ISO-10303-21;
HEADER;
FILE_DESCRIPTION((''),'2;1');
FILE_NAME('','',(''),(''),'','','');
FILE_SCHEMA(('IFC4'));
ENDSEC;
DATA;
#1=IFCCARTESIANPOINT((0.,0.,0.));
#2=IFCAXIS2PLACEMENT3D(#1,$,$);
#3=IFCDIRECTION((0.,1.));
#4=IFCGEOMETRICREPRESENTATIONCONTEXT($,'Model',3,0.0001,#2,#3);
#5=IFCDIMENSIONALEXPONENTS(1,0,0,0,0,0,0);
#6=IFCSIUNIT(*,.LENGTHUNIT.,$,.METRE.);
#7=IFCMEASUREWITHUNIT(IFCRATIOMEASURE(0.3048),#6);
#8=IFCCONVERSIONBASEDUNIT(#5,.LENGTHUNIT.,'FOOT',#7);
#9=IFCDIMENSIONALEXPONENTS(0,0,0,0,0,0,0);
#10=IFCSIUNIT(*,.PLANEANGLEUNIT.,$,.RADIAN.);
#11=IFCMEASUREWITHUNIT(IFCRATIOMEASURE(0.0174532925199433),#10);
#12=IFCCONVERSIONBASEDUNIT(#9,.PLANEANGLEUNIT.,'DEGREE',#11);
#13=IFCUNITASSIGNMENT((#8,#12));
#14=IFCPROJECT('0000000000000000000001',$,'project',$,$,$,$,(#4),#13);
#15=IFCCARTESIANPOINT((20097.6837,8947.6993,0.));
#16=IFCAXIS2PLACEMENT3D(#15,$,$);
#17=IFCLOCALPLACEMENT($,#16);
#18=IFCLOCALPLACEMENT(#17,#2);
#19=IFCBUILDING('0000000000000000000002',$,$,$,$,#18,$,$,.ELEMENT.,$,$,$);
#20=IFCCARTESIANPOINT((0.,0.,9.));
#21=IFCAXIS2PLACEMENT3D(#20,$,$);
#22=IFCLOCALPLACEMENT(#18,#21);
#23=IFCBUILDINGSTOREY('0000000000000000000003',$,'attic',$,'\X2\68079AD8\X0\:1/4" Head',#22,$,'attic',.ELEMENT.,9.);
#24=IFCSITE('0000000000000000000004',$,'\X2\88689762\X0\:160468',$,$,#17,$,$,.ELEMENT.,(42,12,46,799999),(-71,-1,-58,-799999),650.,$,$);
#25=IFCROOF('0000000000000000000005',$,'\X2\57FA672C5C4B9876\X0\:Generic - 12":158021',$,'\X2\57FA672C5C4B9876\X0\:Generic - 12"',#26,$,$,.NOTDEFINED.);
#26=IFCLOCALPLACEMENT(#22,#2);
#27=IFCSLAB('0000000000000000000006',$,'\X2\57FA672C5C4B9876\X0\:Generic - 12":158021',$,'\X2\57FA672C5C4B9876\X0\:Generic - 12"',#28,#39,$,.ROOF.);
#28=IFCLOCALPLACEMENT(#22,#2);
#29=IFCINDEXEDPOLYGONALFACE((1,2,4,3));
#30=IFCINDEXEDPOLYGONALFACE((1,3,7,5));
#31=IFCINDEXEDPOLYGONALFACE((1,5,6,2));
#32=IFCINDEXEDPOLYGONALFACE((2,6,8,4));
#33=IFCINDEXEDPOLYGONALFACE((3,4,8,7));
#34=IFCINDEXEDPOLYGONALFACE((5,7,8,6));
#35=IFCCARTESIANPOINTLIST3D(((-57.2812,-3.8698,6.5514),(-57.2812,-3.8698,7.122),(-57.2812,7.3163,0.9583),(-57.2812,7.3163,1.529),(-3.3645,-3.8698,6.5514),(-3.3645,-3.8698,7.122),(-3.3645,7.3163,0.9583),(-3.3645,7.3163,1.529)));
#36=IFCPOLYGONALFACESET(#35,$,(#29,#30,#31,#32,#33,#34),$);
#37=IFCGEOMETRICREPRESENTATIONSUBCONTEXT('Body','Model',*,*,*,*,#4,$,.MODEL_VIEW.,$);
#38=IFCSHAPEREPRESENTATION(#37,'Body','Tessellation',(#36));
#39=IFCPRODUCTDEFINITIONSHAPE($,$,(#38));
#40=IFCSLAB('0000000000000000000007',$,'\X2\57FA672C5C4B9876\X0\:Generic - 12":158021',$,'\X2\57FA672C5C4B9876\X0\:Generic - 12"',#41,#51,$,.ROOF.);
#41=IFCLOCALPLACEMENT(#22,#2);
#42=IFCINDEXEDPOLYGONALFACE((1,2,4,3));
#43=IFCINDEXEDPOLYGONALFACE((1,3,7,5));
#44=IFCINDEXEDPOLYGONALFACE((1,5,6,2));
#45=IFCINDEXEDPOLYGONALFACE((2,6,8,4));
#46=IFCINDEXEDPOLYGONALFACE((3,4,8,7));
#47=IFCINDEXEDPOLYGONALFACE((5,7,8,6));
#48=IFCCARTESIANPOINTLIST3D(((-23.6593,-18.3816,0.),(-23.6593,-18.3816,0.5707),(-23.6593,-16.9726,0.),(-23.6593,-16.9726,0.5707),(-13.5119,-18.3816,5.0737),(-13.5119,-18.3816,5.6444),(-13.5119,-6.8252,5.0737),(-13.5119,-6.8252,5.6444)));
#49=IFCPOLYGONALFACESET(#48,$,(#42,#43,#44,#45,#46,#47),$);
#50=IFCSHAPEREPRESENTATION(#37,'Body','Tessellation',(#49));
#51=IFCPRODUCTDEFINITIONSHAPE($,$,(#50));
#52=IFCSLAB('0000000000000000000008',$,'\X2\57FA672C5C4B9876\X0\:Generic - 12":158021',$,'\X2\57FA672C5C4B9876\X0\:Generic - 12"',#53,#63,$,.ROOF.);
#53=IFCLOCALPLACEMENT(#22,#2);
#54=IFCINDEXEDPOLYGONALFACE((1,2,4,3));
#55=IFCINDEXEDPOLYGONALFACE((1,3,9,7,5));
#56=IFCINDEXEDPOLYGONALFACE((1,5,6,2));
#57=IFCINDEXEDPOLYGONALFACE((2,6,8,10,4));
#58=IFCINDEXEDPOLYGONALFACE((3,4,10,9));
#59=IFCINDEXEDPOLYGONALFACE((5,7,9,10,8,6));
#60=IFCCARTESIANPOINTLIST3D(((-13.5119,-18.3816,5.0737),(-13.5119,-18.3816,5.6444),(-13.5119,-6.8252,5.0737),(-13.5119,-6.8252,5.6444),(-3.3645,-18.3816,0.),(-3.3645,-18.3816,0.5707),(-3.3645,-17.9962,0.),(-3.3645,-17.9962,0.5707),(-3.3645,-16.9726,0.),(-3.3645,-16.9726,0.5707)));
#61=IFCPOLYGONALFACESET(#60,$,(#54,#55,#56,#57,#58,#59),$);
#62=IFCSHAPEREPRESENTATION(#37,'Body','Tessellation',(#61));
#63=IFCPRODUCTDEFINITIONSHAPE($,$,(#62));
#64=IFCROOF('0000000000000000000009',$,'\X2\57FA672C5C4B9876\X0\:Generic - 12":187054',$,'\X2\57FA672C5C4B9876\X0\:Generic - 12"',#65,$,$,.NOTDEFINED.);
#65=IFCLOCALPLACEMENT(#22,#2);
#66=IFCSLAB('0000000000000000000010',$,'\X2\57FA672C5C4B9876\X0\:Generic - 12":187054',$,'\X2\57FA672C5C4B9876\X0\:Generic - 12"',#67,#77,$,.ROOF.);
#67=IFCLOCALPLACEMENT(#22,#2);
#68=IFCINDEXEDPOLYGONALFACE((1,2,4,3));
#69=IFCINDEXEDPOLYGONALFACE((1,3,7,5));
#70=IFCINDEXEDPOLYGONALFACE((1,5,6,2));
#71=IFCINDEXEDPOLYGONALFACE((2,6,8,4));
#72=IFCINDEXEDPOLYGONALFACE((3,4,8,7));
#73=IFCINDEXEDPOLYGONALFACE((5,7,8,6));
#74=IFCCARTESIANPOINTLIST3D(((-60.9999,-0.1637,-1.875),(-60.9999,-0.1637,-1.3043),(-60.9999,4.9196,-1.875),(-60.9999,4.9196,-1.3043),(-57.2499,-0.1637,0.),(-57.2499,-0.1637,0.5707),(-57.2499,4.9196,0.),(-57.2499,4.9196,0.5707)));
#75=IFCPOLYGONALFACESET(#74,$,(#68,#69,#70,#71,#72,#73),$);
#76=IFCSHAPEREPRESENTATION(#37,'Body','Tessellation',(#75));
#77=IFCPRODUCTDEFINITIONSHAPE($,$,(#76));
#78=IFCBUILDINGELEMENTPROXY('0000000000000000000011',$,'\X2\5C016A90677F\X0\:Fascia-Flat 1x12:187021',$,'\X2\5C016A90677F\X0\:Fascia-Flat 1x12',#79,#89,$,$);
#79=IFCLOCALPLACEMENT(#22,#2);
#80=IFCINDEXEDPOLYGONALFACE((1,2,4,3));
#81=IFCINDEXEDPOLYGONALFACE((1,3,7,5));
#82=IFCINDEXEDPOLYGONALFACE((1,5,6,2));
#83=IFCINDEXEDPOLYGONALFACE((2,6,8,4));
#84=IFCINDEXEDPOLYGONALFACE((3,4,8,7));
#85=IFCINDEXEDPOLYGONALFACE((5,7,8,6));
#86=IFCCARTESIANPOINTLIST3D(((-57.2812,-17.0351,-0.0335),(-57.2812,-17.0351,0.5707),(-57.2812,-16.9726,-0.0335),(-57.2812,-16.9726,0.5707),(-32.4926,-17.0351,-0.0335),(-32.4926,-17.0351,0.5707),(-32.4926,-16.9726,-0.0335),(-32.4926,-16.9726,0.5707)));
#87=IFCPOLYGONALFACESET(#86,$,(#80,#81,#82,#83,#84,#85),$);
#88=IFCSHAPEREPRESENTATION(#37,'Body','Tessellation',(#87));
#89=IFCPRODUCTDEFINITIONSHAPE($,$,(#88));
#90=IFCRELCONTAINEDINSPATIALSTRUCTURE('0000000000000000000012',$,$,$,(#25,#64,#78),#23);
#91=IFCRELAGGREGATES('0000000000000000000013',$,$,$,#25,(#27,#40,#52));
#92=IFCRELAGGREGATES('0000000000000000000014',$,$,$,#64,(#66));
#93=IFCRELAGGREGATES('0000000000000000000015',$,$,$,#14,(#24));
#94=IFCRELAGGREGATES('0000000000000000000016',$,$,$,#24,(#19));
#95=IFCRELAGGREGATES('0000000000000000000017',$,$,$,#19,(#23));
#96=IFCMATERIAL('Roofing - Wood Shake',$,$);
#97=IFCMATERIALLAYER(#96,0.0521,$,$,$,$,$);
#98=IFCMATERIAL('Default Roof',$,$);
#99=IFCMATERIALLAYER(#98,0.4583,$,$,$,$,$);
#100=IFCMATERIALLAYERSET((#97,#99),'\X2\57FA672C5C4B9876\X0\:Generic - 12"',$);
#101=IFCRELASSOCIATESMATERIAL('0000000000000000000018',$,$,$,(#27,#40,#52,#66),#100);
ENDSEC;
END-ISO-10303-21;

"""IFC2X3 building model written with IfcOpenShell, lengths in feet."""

from ifc_helpers import new_model, entity, si_unit, converted_unit, direction, frame, frame_2d, origin, origin_2d_with_axis, place, context, subcontext, project, spatial, polyline, rectangle, outline, extrude, material, layer, layer_set, element, aggregate, save


model = new_model("IFC2X3")

# Units and contexts
model_context = context("Model", 3, precision=0.0001, world=origin(), true_north=direction((0.0, 1.0)))
body_context = subcontext(model_context, "Body", "Model", "MODEL_VIEW")
ifc_project = project(units=[converted_unit("LENGTHUNIT", "FOOT", entity("IfcRatioMeasure", 0.3048), si_unit("LENGTHUNIT", "METRE"), dimensions=[1, 0, 0, 0, 0, 0, 0]), converted_unit("PLANEANGLEUNIT", "DEGREE", entity("IfcRatioMeasure", 0.0174532925199433), si_unit("PLANEANGLEUNIT", "RADIAN"), dimensions=[0, 0, 0, 0, 0, 0, 0])], contexts=[model_context])

# Site, building, storey
site_placement = place(None, frame((20097.6837, 8947.6993, 0.0)))
site = spatial("IfcSite", under=ifc_project, at=site_placement, Name="表面:160468", CompositionType="ELEMENT", RefLatitude=(42, 12, 46, 799999), RefLongitude=(-71, -1, -58, -799999), RefElevation=650.0)
building_placement = place(site_placement, origin())
building = spatial("IfcBuilding", under=site, at=building_placement, CompositionType="ELEMENT")
storey_placement = place(building_placement, frame((0.0, 0.0, 9.0)))
storey = spatial("IfcBuildingStorey", under=building, at=storey_placement, Name="attic", ObjectType="标高:1/4\" Head", LongName="attic", CompositionType="ELEMENT", Elevation=9.0)

# Roof, slabs
roof_1_placement = place(storey_placement, frame((-57.2812, -18.3816, 0.0)))
roof_1 = element("IfcRoof", 1, at=roof_1_placement, inside=storey, Name="基本屋顶:Generic - 12\":158021", ObjectType="基本屋顶:Generic - 12\"", ShapeType="NOTDEFINED")
ifc_material_1 = material(Name="Roofing - Wood Shake")
ifc_layer_1 = layer(ifc_material_1, 0.0521)
ifc_material_2 = material(Name="Default Roof")
ifc_layer_2 = layer(ifc_material_2, 0.4583)
ifc_layer_set_1 = layer_set([ifc_layer_1, ifc_layer_2], Name="基本屋顶:Generic - 12\"")
slab_1_placement = place(roof_1_placement, origin())
slab_1 = element("IfcSlab", 2, at=slab_1_placement, material=ifc_layer_set_1, Name="基本屋顶:Generic - 12\":158021", ObjectType="基本屋顶:Generic - 12\"", PredefinedType="ROOF", context=body_context, shape_type="SweptSolid", body=[
    extrude(rectangle(XDim=53.9167, YDim=12.5064, at=frame_2d((0.0, 0.0), x_axis=(1.0, 0.0))), frame((26.9583, 20.1049, 3.7549), z_axis=(0.0, 0.447214, 0.894427), x_axis=(1.0, 0.0, 0.0)), (0.0, -0.447214, 0.894427), 0.5707),
])
slab_2_placement = place(roof_1_placement, origin())
slab_2 = element("IfcSlab", 3, at=slab_2_placement, material=ifc_layer_set_1, Name="基本屋顶:Generic - 12\":158021", ObjectType="基本屋顶:Generic - 12\"", PredefinedType="ROOF", context=body_context, shape_type="SweptSolid", body=[
    extrude(outline(polyline([(-5.6726, -5.7782), (5.6726, -5.7782), (5.6726, 5.7782), (-5.6726, -4.3692), (-5.6726, -5.7782)])), frame((38.6956, 5.7782, 2.5368), z_axis=(-0.447214, 0.0, 0.894427), x_axis=(0.894427, 0.0, 0.447214)), (0.447214, 0.0, 0.894427), 0.5707),
])
slab_3_placement = place(roof_1_placement, origin())
slab_3 = element("IfcSlab", 4, at=slab_3_placement, material=ifc_layer_set_1, Name="基本屋顶:Generic - 12\":158021", ObjectType="基本屋顶:Generic - 12\"", PredefinedType="ROOF", context=body_context, shape_type="SweptSolid", body=[
    extrude(outline(polyline([(5.6726, -5.3928), (5.6726, -4.3692), (-5.6726, 5.7782), (-5.6726, -5.7782), (5.6726, -5.7782), (5.6726, -5.3928)])), frame((48.843, 5.7782, 2.5368), z_axis=(0.447214, 0.0, 0.894427), x_axis=(0.894427, 0.0, -0.447214)), (-0.447214, 0.0, 0.894427), 0.5707),
])
aggregate(roof_1, [slab_1, slab_2, slab_3])

# Roof, slab
roof_2_placement = place(storey_placement, frame((-60.9999, -0.1637, -1.875)))
roof_2 = element("IfcRoof", 5, at=roof_2_placement, inside=storey, Name="基本屋顶:Generic - 12\":187054", ObjectType="基本屋顶:Generic - 12\"", ShapeType="NOTDEFINED")
slab_4_placement = place(roof_2_placement, origin())
slab_4 = element("IfcSlab", 6, at=slab_4_placement, material=ifc_layer_set_1, Name="基本屋顶:Generic - 12\":187054", ObjectType="基本屋顶:Generic - 12\"", PredefinedType="ROOF", context=body_context, shape_type="SweptSolid", body=[
    extrude(rectangle(XDim=4.1926, YDim=5.0833, at=origin_2d_with_axis()), frame((1.875, 2.5417, 0.9375), z_axis=(-0.447214, 0.0, 0.894427), x_axis=(0.894427, 0.0, 0.447214)), (0.447214, 0.0, 0.894427), 0.5707),
])
aggregate(roof_2, [slab_4])

# Building element proxy
proxy_1_placement = place(storey_placement, origin())
element("IfcBuildingElementProxy", 7, at=proxy_1_placement, inside=storey, Name="封檐板:Fascia-Flat 1x12:187021", ObjectType="封檐板:Fascia-Flat 1x12", context=body_context, shape_type="SweptSolid", body=[
    extrude(rectangle(XDim=24.7886, YDim=0.0625, at=origin_2d_with_axis()), frame((-44.8869, -17.0038, -0.0335)), (0.0, 0.0, 1.0), 0.6042),
])

save(model, "model.ifc")
